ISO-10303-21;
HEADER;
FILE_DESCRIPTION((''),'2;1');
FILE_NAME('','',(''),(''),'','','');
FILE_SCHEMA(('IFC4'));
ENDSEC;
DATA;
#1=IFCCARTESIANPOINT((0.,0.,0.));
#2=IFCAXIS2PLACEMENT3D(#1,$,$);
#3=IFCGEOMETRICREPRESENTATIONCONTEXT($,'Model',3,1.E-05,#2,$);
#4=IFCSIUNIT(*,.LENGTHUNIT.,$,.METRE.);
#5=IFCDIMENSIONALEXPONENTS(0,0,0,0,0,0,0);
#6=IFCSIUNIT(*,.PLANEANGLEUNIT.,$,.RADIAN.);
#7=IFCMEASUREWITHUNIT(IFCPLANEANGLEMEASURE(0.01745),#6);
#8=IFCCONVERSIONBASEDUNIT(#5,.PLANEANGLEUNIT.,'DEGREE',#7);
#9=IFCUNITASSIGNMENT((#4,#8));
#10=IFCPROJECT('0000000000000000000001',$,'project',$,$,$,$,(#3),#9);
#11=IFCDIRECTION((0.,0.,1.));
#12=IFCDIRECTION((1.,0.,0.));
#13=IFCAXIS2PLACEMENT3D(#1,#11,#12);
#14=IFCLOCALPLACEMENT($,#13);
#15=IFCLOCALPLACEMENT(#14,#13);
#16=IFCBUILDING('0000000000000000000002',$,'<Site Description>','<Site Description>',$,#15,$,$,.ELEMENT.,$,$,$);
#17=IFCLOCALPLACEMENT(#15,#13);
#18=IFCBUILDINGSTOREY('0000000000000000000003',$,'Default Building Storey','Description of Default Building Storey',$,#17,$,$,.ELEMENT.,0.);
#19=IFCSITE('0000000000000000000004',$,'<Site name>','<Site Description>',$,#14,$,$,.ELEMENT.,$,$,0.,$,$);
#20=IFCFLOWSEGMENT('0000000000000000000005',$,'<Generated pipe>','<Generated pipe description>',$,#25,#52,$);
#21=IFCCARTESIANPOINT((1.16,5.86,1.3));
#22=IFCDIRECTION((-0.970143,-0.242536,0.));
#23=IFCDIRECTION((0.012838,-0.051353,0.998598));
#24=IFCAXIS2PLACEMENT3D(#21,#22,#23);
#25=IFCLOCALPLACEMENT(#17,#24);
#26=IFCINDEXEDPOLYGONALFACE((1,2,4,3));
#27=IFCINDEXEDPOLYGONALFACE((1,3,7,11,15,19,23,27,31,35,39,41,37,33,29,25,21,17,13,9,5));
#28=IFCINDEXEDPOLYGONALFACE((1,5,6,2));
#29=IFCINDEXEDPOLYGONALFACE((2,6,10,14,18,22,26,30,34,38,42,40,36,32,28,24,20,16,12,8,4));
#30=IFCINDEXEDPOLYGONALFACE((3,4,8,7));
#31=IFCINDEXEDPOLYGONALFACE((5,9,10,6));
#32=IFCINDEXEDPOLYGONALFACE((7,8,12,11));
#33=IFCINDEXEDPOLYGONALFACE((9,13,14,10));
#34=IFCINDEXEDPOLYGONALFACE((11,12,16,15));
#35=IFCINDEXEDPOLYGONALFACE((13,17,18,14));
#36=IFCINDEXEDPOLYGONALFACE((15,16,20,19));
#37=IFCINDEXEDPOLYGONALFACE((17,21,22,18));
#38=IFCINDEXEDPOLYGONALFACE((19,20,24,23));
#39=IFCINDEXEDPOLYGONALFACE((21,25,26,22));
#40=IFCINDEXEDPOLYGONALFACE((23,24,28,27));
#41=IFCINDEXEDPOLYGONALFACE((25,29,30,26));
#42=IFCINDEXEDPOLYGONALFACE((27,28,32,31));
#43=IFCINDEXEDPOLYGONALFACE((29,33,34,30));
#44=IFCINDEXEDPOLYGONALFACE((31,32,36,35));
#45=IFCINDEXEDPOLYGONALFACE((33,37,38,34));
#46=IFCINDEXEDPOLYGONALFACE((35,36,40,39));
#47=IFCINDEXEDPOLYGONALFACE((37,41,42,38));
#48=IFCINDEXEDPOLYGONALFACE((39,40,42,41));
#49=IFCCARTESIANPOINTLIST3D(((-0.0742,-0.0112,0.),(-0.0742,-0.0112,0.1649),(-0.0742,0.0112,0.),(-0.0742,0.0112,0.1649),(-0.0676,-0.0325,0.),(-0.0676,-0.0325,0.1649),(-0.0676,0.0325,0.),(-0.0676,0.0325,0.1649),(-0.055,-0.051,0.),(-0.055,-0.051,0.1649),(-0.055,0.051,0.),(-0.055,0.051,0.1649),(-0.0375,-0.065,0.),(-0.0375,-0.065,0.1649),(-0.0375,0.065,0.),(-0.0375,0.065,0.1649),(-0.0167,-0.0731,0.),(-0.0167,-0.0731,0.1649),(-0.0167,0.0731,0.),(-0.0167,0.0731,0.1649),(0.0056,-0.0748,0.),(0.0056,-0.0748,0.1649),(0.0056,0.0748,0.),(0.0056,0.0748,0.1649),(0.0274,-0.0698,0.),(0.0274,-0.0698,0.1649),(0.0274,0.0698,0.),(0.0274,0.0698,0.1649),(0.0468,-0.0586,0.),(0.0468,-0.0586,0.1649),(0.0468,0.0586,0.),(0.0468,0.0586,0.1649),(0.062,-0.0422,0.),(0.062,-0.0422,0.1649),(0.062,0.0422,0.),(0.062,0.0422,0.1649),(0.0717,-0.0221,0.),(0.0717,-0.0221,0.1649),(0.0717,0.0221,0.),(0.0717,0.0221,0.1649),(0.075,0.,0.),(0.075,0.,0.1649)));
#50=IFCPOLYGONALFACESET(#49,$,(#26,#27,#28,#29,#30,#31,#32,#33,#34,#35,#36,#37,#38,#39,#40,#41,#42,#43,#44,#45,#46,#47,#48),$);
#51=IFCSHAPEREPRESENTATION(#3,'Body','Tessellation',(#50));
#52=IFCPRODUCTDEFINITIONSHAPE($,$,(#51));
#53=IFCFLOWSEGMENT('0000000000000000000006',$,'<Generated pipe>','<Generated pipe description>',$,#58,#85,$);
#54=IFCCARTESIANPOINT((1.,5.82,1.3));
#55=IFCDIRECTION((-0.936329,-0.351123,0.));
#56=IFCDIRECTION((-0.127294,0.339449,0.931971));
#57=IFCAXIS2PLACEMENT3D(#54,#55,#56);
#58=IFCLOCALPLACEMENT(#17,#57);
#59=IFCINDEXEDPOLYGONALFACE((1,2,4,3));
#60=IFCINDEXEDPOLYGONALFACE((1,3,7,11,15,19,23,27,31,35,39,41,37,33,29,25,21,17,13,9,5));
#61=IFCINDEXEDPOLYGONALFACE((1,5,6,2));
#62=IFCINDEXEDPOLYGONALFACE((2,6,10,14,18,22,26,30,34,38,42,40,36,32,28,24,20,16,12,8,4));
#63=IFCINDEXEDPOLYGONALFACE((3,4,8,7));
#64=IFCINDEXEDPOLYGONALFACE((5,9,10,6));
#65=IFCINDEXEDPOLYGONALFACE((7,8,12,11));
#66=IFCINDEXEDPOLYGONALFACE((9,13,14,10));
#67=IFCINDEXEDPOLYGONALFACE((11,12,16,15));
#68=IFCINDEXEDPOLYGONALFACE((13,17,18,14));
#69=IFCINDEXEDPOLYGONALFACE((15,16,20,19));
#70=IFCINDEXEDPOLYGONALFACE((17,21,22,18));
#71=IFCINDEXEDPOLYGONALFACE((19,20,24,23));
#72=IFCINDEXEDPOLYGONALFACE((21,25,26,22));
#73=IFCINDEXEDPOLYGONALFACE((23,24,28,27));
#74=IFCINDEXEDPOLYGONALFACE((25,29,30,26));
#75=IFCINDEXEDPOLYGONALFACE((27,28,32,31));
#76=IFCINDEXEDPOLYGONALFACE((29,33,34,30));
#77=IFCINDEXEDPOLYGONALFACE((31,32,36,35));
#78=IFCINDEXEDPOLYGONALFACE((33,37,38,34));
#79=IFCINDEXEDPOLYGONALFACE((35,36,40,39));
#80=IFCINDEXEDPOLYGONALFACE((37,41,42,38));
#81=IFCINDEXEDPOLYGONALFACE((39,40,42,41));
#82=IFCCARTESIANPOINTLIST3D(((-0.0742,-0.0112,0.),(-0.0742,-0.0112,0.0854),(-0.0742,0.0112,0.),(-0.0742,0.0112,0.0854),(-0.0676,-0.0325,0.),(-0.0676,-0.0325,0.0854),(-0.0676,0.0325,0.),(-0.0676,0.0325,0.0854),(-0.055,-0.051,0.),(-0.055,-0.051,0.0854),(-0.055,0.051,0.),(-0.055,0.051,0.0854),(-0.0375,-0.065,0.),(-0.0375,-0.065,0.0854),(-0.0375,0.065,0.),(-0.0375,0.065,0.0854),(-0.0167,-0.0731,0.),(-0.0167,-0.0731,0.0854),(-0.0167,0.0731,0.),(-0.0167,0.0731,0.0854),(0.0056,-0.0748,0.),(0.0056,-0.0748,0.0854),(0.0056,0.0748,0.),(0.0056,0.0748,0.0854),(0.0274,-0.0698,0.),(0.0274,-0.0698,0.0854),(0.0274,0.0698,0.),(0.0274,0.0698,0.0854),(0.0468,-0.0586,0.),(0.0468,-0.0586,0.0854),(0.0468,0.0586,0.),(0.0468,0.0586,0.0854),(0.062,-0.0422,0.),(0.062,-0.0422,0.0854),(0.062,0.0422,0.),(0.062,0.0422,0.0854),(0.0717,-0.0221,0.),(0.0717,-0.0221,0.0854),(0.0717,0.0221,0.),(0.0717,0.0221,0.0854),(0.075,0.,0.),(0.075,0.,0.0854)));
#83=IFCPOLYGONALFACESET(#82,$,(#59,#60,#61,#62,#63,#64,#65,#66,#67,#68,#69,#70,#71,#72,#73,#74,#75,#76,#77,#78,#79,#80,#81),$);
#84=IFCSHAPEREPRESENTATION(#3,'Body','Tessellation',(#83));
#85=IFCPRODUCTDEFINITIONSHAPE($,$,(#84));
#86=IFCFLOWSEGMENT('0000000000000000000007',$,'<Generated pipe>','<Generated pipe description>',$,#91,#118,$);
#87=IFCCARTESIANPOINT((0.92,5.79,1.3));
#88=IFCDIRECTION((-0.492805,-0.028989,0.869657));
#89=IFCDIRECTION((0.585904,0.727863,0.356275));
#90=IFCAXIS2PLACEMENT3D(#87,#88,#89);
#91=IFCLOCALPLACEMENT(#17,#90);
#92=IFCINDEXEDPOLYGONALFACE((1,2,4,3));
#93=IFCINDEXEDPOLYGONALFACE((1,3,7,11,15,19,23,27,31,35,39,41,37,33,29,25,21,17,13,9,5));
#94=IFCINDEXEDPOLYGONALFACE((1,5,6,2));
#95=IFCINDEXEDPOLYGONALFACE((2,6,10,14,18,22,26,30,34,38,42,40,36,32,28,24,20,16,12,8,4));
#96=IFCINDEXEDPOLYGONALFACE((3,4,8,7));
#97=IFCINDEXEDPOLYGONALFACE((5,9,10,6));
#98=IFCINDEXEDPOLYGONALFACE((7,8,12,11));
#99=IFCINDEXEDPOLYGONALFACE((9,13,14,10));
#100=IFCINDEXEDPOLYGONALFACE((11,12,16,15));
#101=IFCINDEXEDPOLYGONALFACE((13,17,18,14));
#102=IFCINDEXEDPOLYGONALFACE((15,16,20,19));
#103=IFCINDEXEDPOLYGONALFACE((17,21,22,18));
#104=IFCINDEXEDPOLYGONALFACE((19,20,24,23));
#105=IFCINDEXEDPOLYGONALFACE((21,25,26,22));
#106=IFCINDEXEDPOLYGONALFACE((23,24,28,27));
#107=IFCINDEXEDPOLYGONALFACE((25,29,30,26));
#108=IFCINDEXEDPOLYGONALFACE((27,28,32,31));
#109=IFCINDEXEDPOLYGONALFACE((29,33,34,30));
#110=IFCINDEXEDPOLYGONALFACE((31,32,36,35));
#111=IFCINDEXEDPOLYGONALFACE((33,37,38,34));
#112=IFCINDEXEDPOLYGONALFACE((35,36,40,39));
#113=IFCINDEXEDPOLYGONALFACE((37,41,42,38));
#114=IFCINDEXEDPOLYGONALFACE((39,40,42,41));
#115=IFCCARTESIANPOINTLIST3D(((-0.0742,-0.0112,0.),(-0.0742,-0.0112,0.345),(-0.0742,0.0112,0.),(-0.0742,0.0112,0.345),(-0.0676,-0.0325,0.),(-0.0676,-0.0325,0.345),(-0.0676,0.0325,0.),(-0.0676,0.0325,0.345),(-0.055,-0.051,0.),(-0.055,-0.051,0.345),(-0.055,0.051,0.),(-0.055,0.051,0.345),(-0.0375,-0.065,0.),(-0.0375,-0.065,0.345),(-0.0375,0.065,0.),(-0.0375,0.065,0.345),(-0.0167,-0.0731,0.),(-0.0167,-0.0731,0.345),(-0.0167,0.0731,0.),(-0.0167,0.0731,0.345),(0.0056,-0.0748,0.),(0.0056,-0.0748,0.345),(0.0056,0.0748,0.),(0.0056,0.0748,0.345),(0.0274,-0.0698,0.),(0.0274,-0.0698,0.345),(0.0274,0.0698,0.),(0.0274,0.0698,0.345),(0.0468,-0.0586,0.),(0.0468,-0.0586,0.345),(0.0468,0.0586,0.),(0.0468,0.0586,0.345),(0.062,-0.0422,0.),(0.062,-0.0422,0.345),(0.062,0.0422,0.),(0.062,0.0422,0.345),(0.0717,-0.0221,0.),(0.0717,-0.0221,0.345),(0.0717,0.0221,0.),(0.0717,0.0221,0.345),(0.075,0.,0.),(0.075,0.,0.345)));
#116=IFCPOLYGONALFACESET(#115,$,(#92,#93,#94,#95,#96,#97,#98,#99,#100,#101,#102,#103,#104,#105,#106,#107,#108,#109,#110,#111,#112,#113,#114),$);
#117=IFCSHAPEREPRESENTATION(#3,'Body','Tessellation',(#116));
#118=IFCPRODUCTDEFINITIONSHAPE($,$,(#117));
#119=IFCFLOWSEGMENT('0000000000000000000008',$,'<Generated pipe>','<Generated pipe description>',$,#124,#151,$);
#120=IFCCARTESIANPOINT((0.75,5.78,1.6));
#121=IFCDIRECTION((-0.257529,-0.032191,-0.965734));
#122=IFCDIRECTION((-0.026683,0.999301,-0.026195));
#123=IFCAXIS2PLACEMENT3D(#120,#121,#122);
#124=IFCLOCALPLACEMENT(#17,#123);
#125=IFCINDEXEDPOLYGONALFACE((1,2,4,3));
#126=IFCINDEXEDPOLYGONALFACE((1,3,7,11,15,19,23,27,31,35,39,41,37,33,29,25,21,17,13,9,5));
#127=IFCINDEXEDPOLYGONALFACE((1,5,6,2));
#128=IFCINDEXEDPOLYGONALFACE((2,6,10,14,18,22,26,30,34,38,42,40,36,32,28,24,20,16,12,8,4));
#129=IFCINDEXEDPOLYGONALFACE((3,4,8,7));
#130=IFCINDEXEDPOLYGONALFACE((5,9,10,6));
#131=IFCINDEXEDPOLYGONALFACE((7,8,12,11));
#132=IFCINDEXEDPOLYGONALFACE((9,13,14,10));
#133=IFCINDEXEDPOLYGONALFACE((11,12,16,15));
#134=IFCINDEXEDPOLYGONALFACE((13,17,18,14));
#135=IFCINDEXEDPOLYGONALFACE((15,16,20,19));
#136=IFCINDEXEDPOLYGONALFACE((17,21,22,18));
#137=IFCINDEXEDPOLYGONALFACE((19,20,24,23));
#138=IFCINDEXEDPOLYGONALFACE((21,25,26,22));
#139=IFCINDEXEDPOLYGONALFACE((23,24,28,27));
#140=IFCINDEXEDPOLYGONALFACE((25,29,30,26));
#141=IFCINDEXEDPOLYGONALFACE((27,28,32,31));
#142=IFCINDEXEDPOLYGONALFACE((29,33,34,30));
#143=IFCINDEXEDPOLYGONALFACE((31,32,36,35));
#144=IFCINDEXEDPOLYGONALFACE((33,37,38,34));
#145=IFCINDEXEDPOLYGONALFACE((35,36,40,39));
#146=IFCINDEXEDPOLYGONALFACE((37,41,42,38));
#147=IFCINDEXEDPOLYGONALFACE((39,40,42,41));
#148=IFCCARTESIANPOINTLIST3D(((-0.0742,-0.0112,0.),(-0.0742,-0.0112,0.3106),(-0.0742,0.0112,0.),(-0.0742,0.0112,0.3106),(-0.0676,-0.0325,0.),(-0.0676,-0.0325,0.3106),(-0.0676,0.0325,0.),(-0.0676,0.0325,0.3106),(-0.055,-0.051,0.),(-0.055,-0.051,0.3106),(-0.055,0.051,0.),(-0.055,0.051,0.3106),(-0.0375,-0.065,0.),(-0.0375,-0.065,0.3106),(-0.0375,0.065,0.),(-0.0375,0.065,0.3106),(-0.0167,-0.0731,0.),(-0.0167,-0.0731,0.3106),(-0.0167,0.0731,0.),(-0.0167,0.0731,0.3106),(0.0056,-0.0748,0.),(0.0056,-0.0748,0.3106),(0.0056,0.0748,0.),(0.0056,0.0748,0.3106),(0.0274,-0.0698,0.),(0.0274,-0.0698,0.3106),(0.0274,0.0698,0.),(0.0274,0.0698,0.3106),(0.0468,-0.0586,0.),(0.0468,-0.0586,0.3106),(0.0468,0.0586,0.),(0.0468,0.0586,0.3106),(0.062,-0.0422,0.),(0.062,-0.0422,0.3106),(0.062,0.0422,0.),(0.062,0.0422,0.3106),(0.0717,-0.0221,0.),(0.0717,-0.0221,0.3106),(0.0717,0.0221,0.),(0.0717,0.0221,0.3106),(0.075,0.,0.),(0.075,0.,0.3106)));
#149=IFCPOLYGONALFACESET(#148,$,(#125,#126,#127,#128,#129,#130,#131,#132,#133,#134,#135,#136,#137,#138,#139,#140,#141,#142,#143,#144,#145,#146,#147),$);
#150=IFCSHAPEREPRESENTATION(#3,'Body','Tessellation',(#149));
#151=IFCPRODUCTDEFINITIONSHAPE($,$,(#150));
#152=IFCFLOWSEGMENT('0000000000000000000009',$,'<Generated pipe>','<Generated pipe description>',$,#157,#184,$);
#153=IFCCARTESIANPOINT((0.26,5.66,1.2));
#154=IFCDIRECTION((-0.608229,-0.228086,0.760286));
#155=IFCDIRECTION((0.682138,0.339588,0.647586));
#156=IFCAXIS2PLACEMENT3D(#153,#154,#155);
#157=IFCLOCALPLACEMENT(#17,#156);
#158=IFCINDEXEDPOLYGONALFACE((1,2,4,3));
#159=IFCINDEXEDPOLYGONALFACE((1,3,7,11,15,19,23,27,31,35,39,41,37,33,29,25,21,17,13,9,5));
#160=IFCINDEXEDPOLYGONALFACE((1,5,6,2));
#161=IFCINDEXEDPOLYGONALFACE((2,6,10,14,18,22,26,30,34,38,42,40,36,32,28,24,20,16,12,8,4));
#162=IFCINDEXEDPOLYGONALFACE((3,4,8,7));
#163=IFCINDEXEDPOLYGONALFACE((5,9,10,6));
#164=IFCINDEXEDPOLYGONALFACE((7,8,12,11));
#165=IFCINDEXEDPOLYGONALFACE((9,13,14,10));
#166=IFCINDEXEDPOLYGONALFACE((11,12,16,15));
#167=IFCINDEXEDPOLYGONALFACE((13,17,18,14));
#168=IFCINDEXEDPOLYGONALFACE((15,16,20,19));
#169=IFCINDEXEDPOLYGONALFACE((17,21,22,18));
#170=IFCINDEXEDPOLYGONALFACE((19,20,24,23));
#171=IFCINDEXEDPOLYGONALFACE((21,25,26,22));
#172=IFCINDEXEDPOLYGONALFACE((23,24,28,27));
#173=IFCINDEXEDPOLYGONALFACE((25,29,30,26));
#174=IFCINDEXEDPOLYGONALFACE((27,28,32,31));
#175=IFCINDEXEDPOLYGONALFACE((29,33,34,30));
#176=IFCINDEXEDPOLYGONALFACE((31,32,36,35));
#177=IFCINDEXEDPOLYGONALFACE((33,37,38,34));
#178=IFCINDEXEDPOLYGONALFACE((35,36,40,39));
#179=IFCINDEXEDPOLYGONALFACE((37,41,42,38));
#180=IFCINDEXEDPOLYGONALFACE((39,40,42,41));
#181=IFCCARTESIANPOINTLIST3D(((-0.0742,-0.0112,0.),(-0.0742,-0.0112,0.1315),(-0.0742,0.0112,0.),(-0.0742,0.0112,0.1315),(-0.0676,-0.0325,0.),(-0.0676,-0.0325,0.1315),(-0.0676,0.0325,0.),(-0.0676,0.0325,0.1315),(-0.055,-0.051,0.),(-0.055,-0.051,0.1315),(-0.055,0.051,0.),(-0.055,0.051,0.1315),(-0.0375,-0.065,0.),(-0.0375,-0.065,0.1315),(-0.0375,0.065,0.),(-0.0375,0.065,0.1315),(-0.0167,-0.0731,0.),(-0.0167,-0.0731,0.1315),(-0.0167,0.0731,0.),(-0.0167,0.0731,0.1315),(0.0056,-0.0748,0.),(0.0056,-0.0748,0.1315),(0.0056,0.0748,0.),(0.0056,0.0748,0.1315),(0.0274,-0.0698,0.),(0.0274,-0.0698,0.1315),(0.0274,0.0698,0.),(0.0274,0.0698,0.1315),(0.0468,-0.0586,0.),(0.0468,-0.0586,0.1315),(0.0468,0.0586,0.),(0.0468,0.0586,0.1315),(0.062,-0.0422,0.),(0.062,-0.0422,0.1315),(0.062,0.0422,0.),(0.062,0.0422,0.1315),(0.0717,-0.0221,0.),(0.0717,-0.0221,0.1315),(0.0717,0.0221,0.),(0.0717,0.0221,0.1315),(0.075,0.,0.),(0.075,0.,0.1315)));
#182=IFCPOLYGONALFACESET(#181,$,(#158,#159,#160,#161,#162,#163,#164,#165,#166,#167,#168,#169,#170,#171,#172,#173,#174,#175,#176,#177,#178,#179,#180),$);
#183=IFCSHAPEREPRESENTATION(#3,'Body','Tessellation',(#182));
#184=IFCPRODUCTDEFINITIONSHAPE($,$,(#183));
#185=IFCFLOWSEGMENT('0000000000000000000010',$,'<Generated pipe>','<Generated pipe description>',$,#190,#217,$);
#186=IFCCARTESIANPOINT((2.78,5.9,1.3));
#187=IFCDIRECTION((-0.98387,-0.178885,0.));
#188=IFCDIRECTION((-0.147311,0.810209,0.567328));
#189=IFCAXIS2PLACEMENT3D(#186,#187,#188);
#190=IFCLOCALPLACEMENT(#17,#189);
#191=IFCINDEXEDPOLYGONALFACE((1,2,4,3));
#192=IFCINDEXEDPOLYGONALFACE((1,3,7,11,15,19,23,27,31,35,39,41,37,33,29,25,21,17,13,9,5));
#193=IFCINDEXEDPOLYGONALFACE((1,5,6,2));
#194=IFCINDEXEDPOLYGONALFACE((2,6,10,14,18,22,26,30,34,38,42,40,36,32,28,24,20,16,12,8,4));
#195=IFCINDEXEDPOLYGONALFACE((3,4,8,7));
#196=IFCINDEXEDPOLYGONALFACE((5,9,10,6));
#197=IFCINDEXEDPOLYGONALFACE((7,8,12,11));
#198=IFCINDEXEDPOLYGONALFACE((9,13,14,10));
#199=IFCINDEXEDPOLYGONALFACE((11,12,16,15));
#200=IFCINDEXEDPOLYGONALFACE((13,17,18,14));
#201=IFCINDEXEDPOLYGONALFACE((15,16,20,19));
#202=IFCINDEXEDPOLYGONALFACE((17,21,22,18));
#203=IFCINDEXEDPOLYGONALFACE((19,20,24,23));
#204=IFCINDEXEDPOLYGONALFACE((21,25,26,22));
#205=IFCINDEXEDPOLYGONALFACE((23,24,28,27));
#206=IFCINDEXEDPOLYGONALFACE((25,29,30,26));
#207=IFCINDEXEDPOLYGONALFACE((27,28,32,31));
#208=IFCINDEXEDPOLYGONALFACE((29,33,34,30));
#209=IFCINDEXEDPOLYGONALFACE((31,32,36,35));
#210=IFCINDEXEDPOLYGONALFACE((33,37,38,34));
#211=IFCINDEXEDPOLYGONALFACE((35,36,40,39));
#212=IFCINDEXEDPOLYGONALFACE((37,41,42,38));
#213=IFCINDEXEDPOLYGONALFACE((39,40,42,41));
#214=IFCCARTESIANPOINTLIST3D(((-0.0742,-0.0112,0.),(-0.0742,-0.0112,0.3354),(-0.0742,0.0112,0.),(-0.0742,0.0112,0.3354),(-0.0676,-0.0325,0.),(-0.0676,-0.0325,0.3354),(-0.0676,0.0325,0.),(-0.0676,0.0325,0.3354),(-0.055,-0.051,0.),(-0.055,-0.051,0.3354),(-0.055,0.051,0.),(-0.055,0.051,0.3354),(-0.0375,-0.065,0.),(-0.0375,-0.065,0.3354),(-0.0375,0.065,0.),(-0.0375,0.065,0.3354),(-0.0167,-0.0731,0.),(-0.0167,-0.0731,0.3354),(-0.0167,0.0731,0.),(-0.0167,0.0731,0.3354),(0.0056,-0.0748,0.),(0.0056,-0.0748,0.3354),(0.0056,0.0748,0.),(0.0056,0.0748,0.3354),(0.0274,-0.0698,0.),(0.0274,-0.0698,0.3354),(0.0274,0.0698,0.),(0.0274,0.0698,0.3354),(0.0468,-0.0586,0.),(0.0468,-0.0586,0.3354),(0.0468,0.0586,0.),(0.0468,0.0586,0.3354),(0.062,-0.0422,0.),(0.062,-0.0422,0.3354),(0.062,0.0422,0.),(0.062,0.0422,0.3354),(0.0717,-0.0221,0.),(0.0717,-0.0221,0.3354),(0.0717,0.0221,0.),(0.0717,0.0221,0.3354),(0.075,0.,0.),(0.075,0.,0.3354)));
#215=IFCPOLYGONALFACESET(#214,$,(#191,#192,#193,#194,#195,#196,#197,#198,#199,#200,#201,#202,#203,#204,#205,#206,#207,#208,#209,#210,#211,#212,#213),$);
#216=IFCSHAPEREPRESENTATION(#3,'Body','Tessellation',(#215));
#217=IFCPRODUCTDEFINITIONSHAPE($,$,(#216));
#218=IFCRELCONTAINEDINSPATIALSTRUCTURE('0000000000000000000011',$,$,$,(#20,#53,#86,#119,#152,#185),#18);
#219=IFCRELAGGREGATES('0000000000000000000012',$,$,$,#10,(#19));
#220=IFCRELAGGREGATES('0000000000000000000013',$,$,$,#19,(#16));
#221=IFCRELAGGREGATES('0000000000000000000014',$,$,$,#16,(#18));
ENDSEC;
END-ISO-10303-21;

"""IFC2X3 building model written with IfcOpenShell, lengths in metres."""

from ifc_helpers import new_model, entity, si_unit, converted_unit, frame, origin, origin_with_axes, origin_2d_with_axis, place, context, project, spatial, circle, extrude, element, save


model = new_model("IFC2X3")

# Units and contexts
model_context = context("Model", 3, precision=1e-05, world=origin())
ifc_project = project(units=[si_unit("LENGTHUNIT", "METRE"), converted_unit("PLANEANGLEUNIT", "DEGREE", entity("IfcPlaneAngleMeasure", 0.01745), si_unit("PLANEANGLEUNIT", "RADIAN"), dimensions=[0, 0, 0, 0, 0, 0, 0])], contexts=[model_context])

# Site, building, storey
site_placement = place(None, origin_with_axes())
site = spatial("IfcSite", under=ifc_project, at=site_placement, Name="<Site name>", Description="<Site Description>", CompositionType="ELEMENT", RefElevation=0.0)
building_placement = place(site_placement, origin_with_axes())
building = spatial("IfcBuilding", under=site, at=building_placement, Name="<Site Description>", Description="<Site Description>", CompositionType="ELEMENT")
storey_placement = place(building_placement, origin_with_axes())
storey = spatial("IfcBuildingStorey", under=building, at=storey_placement, Name="Default Building Storey", Description="Description of Default Building Storey", CompositionType="ELEMENT", Elevation=0.0)

# Flow segments
flow_segment_1_placement = place(storey_placement, frame((1.16, 5.86, 1.3), z_axis=(-0.970143, -0.242536, 0.0), x_axis=(0.012838, -0.051353, 0.998598)))
element("IfcFlowSegment", 1, at=flow_segment_1_placement, inside=storey, Name="<Generated pipe>", Description="<Generated pipe description>", context=model_context, shape_type="SweptSolid", body=[
    extrude(circle(Radius=0.075, at=origin_2d_with_axis()), origin_with_axes(), (0.0, 0.0, 1.0), 0.1649),
])
flow_segment_2_placement = place(storey_placement, frame((1.0, 5.82, 1.3), z_axis=(-0.936329, -0.351123, 0.0), x_axis=(-0.127294, 0.339449, 0.931971)))
element("IfcFlowSegment", 2, at=flow_segment_2_placement, inside=storey, Name="<Generated pipe>", Description="<Generated pipe description>", context=model_context, shape_type="SweptSolid", body=[
    extrude(circle(Radius=0.075, at=origin_2d_with_axis()), origin_with_axes(), (0.0, 0.0, 1.0), 0.0854),
])
flow_segment_3_placement = place(storey_placement, frame((0.92, 5.79, 1.3), z_axis=(-0.492805, -0.028989, 0.869657), x_axis=(0.585904, 0.727863, 0.356275)))
element("IfcFlowSegment", 3, at=flow_segment_3_placement, inside=storey, Name="<Generated pipe>", Description="<Generated pipe description>", context=model_context, shape_type="SweptSolid", body=[
    extrude(circle(Radius=0.075, at=origin_2d_with_axis()), origin_with_axes(), (0.0, 0.0, 1.0), 0.345),
])
flow_segment_4_placement = place(storey_placement, frame((0.75, 5.78, 1.6), z_axis=(-0.257529, -0.032191, -0.965734), x_axis=(-0.026683, 0.999301, -0.026195)))
element("IfcFlowSegment", 4, at=flow_segment_4_placement, inside=storey, Name="<Generated pipe>", Description="<Generated pipe description>", context=model_context, shape_type="SweptSolid", body=[
    extrude(circle(Radius=0.075, at=origin_2d_with_axis()), origin_with_axes(), (0.0, 0.0, 1.0), 0.3106),
])
flow_segment_5_placement = place(storey_placement, frame((0.26, 5.66, 1.2), z_axis=(-0.608229, -0.228086, 0.760286), x_axis=(0.682138, 0.339588, 0.647586)))
element("IfcFlowSegment", 5, at=flow_segment_5_placement, inside=storey, Name="<Generated pipe>", Description="<Generated pipe description>", context=model_context, shape_type="SweptSolid", body=[
    extrude(circle(Radius=0.075, at=origin_2d_with_axis()), origin_with_axes(), (0.0, 0.0, 1.0), 0.1315),
])
flow_segment_6_placement = place(storey_placement, frame((2.78, 5.9, 1.3), z_axis=(-0.98387, -0.178885, 0.0), x_axis=(-0.147311, 0.810209, 0.567328)))
element("IfcFlowSegment", 6, at=flow_segment_6_placement, inside=storey, Name="<Generated pipe>", Description="<Generated pipe description>", context=model_context, shape_type="SweptSolid", body=[
    extrude(circle(Radius=0.075, at=origin_2d_with_axis()), origin_with_axes(), (0.0, 0.0, 1.0), 0.3354),
])

save(model, "model.ifc")
